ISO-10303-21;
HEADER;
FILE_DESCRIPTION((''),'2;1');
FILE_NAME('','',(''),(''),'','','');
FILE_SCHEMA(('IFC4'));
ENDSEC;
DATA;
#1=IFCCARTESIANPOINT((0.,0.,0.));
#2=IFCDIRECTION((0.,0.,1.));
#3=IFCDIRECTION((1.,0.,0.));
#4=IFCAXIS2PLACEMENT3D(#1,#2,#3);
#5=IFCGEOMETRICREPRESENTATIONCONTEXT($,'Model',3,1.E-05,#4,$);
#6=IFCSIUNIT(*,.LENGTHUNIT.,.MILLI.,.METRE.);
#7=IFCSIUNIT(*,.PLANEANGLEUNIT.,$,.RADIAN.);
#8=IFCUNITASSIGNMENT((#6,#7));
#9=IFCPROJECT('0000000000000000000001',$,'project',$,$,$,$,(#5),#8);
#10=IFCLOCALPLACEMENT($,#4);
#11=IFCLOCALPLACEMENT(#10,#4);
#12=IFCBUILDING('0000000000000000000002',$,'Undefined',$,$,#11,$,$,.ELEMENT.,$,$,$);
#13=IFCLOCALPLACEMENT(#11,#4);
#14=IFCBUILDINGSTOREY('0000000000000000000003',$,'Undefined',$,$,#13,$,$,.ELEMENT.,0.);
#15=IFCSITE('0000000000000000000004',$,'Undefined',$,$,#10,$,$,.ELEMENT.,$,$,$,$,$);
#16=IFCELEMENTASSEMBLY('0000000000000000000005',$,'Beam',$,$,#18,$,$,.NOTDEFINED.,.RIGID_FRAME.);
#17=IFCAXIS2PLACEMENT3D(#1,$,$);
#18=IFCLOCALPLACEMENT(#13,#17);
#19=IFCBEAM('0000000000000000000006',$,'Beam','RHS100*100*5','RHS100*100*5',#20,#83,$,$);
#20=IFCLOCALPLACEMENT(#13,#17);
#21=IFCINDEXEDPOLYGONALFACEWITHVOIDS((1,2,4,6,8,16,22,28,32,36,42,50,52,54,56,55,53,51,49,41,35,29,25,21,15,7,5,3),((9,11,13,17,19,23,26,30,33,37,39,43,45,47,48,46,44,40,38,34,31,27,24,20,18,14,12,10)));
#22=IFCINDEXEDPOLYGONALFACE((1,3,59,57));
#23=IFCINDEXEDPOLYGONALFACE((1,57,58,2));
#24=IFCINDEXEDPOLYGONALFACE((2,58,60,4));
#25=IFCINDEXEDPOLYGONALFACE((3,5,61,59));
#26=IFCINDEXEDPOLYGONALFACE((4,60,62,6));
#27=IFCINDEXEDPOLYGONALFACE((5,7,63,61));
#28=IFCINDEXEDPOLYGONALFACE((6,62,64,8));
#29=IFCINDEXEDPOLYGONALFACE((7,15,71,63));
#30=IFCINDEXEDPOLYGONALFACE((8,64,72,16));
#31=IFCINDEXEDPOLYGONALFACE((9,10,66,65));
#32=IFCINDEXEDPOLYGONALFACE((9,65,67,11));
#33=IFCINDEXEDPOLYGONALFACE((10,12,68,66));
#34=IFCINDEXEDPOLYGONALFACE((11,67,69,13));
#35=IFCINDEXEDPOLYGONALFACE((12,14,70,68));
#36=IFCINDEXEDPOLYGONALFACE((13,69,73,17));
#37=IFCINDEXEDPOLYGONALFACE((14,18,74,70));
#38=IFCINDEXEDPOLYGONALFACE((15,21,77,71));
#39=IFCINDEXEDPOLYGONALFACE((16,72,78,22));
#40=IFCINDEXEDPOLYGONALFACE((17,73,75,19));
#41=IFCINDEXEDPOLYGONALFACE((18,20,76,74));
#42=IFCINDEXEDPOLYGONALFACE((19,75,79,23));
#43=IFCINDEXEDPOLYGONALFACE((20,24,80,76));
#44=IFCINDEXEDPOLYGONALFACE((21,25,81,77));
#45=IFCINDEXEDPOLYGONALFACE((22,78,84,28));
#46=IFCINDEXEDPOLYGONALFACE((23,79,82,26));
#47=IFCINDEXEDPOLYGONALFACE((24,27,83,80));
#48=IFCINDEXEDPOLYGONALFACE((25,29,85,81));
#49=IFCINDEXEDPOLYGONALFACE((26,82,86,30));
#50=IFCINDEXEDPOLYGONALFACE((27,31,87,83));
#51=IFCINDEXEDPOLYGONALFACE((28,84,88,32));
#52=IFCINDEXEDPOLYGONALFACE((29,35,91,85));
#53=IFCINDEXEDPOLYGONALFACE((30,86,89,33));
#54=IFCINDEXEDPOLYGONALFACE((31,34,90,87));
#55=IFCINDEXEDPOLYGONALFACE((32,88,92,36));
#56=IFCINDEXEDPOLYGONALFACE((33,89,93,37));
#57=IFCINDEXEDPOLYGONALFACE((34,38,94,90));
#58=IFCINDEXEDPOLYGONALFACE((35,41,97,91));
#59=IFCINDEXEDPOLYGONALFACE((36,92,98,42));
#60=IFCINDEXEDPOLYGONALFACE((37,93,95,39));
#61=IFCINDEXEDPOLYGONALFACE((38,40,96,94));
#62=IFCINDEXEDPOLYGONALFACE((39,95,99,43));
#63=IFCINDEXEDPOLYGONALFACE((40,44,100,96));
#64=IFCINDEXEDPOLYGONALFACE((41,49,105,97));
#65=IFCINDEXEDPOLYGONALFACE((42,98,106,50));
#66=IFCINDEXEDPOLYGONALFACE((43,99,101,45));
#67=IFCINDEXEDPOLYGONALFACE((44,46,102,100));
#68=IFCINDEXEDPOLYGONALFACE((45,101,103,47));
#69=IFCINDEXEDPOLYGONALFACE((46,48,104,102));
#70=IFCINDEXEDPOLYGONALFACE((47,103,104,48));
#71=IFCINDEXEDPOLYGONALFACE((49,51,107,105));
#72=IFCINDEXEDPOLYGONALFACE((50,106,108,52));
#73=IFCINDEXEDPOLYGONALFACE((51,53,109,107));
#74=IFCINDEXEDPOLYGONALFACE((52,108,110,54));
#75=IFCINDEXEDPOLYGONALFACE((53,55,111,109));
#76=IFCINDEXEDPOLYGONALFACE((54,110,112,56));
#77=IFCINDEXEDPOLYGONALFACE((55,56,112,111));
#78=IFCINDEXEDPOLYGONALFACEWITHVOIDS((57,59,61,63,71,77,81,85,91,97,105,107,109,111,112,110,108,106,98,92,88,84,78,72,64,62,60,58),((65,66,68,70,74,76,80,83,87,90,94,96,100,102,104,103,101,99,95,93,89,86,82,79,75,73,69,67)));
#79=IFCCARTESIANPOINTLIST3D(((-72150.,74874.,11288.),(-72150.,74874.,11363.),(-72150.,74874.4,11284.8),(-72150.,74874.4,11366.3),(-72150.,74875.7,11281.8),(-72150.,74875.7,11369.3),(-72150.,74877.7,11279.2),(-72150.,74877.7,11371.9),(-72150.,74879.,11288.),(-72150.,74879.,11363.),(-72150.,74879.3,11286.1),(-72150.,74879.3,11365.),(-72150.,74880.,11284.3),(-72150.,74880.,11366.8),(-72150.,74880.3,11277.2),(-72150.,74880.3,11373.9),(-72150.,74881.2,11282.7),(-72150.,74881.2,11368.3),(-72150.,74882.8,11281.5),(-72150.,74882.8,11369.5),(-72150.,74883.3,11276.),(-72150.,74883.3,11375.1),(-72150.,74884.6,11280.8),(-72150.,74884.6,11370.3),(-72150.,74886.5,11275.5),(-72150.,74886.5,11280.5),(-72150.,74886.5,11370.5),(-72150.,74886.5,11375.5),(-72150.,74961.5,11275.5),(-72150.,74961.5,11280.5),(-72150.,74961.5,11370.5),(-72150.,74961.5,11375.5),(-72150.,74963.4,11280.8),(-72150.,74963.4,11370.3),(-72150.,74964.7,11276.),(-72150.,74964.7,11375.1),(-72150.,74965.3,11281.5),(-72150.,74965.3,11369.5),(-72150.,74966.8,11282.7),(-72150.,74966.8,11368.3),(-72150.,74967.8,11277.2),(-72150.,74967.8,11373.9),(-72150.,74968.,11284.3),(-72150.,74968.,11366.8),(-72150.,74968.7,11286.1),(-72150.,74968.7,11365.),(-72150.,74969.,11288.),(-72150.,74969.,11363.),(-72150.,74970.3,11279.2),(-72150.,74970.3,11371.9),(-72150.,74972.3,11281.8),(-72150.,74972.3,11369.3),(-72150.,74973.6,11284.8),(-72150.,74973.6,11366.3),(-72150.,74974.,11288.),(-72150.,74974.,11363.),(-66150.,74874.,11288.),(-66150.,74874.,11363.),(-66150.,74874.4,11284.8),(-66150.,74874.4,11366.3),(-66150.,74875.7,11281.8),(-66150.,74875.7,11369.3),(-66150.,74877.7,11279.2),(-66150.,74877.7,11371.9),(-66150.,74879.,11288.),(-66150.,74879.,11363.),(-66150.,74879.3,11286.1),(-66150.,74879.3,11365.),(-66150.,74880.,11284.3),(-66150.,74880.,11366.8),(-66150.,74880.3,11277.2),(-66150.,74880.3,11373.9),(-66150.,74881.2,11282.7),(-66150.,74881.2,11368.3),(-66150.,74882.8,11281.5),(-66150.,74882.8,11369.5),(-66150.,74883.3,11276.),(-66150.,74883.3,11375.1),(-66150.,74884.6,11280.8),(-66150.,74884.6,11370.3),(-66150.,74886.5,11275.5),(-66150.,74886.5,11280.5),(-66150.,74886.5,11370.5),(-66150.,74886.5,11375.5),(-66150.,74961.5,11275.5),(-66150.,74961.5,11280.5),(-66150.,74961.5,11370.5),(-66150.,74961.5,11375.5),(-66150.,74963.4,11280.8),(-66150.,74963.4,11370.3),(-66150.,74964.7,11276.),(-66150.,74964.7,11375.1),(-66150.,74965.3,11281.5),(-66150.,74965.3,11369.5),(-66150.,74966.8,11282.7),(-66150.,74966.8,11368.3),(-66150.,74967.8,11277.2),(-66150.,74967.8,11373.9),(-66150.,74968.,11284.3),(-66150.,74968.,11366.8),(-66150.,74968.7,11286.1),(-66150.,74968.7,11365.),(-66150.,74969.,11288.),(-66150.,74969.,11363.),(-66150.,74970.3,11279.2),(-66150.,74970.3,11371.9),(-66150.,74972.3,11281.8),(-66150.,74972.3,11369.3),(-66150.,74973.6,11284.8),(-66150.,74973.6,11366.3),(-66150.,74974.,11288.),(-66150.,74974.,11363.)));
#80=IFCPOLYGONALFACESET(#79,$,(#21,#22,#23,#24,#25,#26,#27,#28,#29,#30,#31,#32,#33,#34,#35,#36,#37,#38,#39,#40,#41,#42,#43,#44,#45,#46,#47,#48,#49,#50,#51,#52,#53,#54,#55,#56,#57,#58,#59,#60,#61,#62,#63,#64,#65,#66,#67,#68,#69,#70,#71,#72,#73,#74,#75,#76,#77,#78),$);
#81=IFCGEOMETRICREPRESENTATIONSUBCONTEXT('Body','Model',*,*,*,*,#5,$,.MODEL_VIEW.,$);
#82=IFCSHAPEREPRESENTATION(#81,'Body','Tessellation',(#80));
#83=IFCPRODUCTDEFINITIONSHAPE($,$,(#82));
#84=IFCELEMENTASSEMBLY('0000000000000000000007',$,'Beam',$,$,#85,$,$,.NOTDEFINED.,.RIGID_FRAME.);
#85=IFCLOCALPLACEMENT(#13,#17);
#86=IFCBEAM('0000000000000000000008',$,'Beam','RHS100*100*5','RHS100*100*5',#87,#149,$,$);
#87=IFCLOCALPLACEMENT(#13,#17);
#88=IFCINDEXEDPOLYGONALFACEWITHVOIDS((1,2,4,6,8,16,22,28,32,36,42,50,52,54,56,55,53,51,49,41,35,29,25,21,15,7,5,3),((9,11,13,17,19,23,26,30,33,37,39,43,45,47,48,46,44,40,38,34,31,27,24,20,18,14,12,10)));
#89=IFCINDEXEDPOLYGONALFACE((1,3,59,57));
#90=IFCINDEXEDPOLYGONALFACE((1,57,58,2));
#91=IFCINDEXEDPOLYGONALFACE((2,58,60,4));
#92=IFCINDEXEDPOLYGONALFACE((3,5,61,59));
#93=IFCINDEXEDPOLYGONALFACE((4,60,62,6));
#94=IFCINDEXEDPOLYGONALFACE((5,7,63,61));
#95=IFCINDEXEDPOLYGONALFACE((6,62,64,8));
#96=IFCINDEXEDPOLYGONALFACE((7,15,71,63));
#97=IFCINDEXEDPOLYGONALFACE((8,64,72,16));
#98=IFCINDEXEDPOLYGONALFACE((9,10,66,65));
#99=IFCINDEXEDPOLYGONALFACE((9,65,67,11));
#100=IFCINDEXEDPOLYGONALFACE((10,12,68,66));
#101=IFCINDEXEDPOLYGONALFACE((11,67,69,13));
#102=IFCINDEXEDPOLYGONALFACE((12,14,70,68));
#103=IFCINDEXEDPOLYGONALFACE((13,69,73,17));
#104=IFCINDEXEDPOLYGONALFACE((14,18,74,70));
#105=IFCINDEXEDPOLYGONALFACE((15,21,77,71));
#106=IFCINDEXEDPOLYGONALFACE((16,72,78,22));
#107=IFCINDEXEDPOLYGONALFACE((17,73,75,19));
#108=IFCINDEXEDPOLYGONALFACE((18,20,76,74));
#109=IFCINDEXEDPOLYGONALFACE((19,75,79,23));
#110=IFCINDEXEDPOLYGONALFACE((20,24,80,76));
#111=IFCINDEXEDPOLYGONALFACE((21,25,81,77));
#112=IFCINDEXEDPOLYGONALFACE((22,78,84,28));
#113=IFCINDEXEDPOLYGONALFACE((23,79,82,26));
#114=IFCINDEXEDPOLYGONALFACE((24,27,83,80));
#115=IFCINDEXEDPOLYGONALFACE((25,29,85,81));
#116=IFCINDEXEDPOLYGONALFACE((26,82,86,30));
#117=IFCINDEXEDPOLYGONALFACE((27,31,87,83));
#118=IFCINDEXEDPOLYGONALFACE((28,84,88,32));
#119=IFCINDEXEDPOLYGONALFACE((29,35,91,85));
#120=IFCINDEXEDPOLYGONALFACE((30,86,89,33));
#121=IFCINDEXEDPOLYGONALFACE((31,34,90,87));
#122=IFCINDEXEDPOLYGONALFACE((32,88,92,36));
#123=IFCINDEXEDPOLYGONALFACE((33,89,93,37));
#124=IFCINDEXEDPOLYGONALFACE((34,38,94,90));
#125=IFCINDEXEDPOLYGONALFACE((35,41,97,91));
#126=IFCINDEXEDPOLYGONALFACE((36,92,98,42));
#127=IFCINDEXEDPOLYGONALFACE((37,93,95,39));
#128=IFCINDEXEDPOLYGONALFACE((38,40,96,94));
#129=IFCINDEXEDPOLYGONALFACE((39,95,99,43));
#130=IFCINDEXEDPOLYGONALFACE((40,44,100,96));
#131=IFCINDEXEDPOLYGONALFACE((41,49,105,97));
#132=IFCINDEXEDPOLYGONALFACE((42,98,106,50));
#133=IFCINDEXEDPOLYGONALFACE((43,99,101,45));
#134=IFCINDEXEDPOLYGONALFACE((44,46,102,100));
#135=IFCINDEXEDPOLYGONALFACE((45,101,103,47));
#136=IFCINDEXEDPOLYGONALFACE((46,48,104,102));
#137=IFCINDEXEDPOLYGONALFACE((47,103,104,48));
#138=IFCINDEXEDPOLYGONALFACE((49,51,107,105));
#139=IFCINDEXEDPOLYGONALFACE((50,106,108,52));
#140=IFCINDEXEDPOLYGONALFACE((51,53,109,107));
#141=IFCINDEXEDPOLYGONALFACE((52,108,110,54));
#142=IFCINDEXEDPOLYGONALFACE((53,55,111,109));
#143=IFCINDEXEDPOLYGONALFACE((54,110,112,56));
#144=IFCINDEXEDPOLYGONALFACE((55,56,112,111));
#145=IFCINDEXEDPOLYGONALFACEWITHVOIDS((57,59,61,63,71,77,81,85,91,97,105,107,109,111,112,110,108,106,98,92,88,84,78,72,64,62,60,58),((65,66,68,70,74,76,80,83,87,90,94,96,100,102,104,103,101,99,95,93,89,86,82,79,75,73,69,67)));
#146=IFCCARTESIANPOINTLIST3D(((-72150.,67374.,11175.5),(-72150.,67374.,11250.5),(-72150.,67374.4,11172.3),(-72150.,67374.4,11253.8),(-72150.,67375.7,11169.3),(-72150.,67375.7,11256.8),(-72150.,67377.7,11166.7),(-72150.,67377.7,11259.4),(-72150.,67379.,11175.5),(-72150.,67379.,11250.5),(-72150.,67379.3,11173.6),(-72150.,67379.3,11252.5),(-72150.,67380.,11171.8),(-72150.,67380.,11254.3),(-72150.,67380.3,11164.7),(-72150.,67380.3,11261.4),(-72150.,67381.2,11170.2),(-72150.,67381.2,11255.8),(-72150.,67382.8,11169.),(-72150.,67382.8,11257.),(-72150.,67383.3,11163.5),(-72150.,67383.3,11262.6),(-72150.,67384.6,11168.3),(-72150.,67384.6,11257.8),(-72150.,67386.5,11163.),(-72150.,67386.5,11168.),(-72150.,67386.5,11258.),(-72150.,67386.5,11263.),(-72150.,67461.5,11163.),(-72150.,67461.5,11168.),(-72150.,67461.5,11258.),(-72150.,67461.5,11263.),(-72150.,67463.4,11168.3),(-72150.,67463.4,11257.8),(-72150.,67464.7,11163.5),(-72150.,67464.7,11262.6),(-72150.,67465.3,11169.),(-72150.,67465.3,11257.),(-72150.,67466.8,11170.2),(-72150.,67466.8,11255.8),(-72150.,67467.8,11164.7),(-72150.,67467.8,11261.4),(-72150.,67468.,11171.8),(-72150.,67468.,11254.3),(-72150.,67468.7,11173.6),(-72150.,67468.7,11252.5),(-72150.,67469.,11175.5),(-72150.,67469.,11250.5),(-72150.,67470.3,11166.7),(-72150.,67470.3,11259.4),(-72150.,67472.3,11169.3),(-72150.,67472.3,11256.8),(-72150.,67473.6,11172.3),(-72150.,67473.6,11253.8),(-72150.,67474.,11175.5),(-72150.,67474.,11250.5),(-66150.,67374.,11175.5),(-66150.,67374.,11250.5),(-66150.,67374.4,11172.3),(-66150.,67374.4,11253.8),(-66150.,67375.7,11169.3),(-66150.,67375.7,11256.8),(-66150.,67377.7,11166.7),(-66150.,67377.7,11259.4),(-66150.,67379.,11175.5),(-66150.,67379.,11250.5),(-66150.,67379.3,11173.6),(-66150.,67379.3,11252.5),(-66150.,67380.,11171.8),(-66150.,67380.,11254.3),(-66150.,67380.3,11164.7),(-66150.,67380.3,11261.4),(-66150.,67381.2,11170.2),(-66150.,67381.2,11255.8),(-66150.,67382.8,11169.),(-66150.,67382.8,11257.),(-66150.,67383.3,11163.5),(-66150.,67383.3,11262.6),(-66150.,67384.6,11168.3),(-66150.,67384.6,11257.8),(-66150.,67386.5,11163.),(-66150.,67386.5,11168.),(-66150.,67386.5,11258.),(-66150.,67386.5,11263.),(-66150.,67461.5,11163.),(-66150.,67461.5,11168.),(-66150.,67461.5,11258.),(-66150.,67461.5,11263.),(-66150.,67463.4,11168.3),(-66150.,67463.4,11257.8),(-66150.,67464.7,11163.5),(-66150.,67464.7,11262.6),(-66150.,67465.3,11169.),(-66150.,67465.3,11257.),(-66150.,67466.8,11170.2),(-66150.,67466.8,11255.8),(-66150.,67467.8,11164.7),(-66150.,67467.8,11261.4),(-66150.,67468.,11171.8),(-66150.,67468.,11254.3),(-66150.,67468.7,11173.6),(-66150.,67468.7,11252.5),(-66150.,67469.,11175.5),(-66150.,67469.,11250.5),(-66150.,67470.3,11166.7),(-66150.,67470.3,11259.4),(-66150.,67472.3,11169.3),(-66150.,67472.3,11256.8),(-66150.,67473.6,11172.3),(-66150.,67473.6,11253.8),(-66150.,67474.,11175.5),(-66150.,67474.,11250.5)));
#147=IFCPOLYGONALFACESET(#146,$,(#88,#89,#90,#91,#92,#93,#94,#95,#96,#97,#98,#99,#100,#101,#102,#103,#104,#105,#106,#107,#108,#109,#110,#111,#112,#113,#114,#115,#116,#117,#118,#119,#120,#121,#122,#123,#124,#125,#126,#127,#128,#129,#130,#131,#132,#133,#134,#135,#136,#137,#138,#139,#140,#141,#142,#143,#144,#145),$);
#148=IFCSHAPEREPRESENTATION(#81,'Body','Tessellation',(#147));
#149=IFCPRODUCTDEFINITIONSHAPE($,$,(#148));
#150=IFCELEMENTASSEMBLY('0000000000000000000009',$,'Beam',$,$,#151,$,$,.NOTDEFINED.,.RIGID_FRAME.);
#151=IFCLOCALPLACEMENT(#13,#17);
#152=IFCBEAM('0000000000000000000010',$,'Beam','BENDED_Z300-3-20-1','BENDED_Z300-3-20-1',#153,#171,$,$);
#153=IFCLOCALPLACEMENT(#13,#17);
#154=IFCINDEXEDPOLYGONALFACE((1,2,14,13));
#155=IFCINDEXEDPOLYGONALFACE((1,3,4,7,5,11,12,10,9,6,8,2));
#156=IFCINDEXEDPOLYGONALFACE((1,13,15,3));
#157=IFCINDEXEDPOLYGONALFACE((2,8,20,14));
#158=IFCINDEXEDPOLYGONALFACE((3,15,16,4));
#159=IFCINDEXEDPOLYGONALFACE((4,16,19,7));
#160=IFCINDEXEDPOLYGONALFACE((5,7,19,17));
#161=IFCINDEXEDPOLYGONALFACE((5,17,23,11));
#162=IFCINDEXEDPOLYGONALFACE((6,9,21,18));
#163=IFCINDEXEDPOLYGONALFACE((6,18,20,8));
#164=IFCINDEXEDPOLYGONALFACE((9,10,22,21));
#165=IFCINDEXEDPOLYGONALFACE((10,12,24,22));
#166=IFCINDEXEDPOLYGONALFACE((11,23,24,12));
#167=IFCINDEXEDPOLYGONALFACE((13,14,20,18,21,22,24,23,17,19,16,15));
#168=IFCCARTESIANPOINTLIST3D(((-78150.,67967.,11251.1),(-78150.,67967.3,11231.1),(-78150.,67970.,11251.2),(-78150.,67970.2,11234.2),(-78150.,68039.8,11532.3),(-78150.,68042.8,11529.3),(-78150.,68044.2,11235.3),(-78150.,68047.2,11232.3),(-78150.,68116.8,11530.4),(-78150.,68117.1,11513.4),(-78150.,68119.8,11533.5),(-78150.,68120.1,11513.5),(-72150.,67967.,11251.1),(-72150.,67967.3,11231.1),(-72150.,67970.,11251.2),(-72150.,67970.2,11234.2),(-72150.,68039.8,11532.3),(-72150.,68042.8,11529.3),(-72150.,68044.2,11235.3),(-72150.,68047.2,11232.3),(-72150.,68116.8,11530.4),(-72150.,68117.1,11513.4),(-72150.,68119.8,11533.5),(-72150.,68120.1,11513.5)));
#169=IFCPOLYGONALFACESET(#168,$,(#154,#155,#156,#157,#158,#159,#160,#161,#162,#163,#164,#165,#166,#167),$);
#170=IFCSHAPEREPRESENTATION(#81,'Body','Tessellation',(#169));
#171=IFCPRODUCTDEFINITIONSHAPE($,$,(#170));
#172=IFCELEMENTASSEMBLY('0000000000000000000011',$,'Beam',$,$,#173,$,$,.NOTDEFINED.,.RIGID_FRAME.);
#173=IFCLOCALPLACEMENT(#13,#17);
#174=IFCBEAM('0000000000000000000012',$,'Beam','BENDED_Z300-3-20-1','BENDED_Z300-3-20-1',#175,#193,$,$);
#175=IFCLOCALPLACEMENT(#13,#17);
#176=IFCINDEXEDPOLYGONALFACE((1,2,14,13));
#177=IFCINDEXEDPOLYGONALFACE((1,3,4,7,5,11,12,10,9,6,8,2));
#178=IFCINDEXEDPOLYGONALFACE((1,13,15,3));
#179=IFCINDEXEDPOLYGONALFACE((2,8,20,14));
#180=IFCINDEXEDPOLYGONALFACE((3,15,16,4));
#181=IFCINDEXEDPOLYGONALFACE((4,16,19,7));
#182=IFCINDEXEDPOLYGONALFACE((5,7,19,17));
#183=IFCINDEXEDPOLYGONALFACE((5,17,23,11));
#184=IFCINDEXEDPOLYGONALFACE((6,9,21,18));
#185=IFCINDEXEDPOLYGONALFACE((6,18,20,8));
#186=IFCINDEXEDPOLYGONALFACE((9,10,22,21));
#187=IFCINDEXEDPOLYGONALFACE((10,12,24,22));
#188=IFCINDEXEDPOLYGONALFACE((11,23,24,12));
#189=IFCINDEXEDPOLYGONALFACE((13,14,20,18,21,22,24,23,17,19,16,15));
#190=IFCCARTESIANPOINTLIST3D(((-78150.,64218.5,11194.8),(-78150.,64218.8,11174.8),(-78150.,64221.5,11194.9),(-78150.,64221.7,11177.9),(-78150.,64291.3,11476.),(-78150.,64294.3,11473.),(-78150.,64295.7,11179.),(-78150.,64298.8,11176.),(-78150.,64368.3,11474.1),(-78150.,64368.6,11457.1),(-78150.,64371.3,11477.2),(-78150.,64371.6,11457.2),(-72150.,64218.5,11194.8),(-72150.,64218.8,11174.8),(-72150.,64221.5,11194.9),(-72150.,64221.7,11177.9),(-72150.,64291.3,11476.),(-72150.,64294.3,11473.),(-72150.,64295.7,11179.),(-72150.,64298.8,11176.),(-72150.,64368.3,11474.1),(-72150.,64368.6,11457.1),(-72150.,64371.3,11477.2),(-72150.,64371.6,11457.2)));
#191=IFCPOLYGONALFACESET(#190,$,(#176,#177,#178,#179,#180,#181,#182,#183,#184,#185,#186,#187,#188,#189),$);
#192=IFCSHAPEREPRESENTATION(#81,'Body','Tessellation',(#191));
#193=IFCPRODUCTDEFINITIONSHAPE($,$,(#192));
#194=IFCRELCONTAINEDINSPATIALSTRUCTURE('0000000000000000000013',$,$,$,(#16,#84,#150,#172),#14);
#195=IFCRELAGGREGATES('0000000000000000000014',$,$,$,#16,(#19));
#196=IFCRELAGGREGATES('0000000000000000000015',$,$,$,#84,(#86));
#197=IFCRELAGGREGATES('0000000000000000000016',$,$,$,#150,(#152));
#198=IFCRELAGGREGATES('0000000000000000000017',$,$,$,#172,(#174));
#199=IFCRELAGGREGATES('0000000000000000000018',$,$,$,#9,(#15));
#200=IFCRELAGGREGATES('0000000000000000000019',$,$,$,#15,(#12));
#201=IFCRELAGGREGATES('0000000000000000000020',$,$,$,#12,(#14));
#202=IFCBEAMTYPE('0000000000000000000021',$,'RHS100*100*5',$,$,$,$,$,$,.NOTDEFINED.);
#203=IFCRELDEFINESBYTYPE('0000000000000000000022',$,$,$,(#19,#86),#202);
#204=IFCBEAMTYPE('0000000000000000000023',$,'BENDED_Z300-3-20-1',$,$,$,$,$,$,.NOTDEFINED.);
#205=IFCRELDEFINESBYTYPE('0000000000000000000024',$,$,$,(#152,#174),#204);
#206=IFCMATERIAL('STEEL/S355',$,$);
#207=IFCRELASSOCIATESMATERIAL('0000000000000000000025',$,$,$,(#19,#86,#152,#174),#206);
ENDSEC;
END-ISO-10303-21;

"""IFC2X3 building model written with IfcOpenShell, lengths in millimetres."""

from ifc_helpers import new_model, si_unit, frame, origin_with_axes, origin_2d_with_axis, place, context, subcontext, project, spatial, polyline, hollow_rectangle, outline, extrude, material, type_object, element, aggregate, save


model = new_model("IFC2X3")

# Units and contexts
model_context = context("Model", 3, precision=1e-05, world=origin_with_axes())
body_context = subcontext(model_context, "Body", "Model", "MODEL_VIEW")
ifc_project = project(units=[si_unit("LENGTHUNIT", "METRE", prefix="MILLI"), si_unit("PLANEANGLEUNIT", "RADIAN")], contexts=[model_context])

# Site, building, storey
site_placement = place(None, origin_with_axes())
site = spatial("IfcSite", under=ifc_project, at=site_placement, Name="Undefined", CompositionType="ELEMENT")
building_placement = place(site_placement, origin_with_axes())
building = spatial("IfcBuilding", under=site, at=building_placement, Name="Undefined", CompositionType="ELEMENT")
storey_placement = place(building_placement, origin_with_axes())
storey = spatial("IfcBuildingStorey", under=building, at=storey_placement, Name="Undefined", CompositionType="ELEMENT", Elevation=0.0)

# Element assemblies, beams
ifc_material = material(Name="STEEL/S355")
beam_type_1 = type_object("IfcBeamType", Name="RHS100*100*5", PredefinedType="NOTDEFINED")
assembly_1_placement = place(storey_placement, origin_with_axes())
assembly_1 = element("IfcElementAssembly", 1, at=assembly_1_placement, inside=storey, Name="Beam", AssemblyPlace="NOTDEFINED", PredefinedType="RIGID_FRAME")
beam_1_placement = place(assembly_1_placement, frame((-66150.0, 74924.0, 11325.5), z_axis=(0.0, 0.0, 1.0), x_axis=(-1.0, 0.0, 0.0)))
beam_1 = element("IfcBeam", 2, at=beam_1_placement, type_object=beam_type_1, material=ifc_material, Name="Beam", Description="RHS100*100*5", ObjectType="RHS100*100*5", context=body_context, shape_type="SweptSolid", body=[
    extrude(hollow_rectangle(XDim=100.0, YDim=100.0, WallThickness=5.0, InnerFilletRadius=7.5, OuterFilletRadius=12.5, at=origin_2d_with_axis()), frame((6000.0, 0.0, 0.0), z_axis=(-1.0, 0.0, 0.0), x_axis=(0.0, -1.0, 0.0)), (0.0, 0.0, 1.0), 6000.0),
])
aggregate(assembly_1, [beam_1])
assembly_2_placement = place(storey_placement, origin_with_axes())
assembly_2 = element("IfcElementAssembly", 3, at=assembly_2_placement, inside=storey, Name="Beam", AssemblyPlace="NOTDEFINED", PredefinedType="RIGID_FRAME")
beam_2_placement = place(assembly_2_placement, frame((-66150.0, 67424.0, 11213.0), z_axis=(0.0, 0.0, 1.0), x_axis=(-1.0, 0.0, 0.0)))
beam_2 = element("IfcBeam", 4, at=beam_2_placement, type_object=beam_type_1, material=ifc_material, Name="Beam", Description="RHS100*100*5", ObjectType="RHS100*100*5", context=body_context, shape_type="SweptSolid", body=[
    extrude(hollow_rectangle(XDim=100.0, YDim=100.0, WallThickness=5.0, InnerFilletRadius=7.5, OuterFilletRadius=12.5, at=origin_2d_with_axis()), frame((6000.0, 0.0, 0.0), z_axis=(-1.0, 0.0, 0.0), x_axis=(0.0, -1.0, 0.0)), (0.0, 0.0, 1.0), 6000.0),
])
aggregate(assembly_2, [beam_2])
assembly_3_placement = place(storey_placement, origin_with_axes())
assembly_3 = element("IfcElementAssembly", 5, at=assembly_3_placement, inside=storey, Name="Beam", AssemblyPlace="NOTDEFINED", PredefinedType="RIGID_FRAME")
beam_type_2 = type_object("IfcBeamType", Name="BENDED_Z300-3-20-1", PredefinedType="NOTDEFINED")
beam_3_placement = place(assembly_3_placement, frame((-72150.0, 68043.5, 11382.3), z_axis=(0.0, -0.014963, 0.999888), x_axis=(-1.0, 0.0, 0.0)))
beam_3 = element("IfcBeam", 6, at=beam_3_placement, type_object=beam_type_2, material=ifc_material, Name="Beam", Description="BENDED_Z300-3-20-1", ObjectType="BENDED_Z300-3-20-1", context=body_context, shape_type="SweptSolid", body=[
    extrude(outline(polyline([(1.5, -150.0), (-78.5, -150.0), (-78.5, -130.0), (-75.5, -130.0), (-75.5, -147.0), (-1.5, -147.0), (-1.5, 150.0), (78.5, 150.0), (78.5, 130.0), (75.5, 130.0), (75.5, 147.0), (1.5, 147.0), (1.5, -150.0)])), frame((6000.0, 0.0, 0.0), z_axis=(-1.0, 0.0, 0.0), x_axis=(0.0, -1.0, 0.0)), (0.0, 0.0, 1.0), 6000.0),
])
aggregate(assembly_3, [beam_3])
assembly_4_placement = place(storey_placement, origin_with_axes())
assembly_4 = element("IfcElementAssembly", 7, at=assembly_4_placement, inside=storey, Name="Beam", AssemblyPlace="NOTDEFINED", PredefinedType="RIGID_FRAME")
beam_4_placement = place(assembly_4_placement, frame((-72150.0, 64295.0, 11326.0), z_axis=(0.0, -0.014963, 0.999888), x_axis=(-1.0, 0.0, 0.0)))
beam_4 = element("IfcBeam", 8, at=beam_4_placement, type_object=beam_type_2, material=ifc_material, Name="Beam", Description="BENDED_Z300-3-20-1", ObjectType="BENDED_Z300-3-20-1", context=body_context, shape_type="SweptSolid", body=[
    extrude(outline(polyline([(1.5, -150.0), (-78.5, -150.0), (-78.5, -130.0), (-75.5, -130.0), (-75.5, -147.0), (-1.5, -147.0), (-1.5, 150.0), (78.5, 150.0), (78.5, 130.0), (75.5, 130.0), (75.5, 147.0), (1.5, 147.0), (1.5, -150.0)])), frame((6000.0, 0.0, 0.0), z_axis=(-1.0, 0.0, 0.0), x_axis=(0.0, -1.0, 0.0)), (0.0, 0.0, 1.0), 6000.0),
])
aggregate(assembly_4, [beam_4])

save(model, "model.ifc")
